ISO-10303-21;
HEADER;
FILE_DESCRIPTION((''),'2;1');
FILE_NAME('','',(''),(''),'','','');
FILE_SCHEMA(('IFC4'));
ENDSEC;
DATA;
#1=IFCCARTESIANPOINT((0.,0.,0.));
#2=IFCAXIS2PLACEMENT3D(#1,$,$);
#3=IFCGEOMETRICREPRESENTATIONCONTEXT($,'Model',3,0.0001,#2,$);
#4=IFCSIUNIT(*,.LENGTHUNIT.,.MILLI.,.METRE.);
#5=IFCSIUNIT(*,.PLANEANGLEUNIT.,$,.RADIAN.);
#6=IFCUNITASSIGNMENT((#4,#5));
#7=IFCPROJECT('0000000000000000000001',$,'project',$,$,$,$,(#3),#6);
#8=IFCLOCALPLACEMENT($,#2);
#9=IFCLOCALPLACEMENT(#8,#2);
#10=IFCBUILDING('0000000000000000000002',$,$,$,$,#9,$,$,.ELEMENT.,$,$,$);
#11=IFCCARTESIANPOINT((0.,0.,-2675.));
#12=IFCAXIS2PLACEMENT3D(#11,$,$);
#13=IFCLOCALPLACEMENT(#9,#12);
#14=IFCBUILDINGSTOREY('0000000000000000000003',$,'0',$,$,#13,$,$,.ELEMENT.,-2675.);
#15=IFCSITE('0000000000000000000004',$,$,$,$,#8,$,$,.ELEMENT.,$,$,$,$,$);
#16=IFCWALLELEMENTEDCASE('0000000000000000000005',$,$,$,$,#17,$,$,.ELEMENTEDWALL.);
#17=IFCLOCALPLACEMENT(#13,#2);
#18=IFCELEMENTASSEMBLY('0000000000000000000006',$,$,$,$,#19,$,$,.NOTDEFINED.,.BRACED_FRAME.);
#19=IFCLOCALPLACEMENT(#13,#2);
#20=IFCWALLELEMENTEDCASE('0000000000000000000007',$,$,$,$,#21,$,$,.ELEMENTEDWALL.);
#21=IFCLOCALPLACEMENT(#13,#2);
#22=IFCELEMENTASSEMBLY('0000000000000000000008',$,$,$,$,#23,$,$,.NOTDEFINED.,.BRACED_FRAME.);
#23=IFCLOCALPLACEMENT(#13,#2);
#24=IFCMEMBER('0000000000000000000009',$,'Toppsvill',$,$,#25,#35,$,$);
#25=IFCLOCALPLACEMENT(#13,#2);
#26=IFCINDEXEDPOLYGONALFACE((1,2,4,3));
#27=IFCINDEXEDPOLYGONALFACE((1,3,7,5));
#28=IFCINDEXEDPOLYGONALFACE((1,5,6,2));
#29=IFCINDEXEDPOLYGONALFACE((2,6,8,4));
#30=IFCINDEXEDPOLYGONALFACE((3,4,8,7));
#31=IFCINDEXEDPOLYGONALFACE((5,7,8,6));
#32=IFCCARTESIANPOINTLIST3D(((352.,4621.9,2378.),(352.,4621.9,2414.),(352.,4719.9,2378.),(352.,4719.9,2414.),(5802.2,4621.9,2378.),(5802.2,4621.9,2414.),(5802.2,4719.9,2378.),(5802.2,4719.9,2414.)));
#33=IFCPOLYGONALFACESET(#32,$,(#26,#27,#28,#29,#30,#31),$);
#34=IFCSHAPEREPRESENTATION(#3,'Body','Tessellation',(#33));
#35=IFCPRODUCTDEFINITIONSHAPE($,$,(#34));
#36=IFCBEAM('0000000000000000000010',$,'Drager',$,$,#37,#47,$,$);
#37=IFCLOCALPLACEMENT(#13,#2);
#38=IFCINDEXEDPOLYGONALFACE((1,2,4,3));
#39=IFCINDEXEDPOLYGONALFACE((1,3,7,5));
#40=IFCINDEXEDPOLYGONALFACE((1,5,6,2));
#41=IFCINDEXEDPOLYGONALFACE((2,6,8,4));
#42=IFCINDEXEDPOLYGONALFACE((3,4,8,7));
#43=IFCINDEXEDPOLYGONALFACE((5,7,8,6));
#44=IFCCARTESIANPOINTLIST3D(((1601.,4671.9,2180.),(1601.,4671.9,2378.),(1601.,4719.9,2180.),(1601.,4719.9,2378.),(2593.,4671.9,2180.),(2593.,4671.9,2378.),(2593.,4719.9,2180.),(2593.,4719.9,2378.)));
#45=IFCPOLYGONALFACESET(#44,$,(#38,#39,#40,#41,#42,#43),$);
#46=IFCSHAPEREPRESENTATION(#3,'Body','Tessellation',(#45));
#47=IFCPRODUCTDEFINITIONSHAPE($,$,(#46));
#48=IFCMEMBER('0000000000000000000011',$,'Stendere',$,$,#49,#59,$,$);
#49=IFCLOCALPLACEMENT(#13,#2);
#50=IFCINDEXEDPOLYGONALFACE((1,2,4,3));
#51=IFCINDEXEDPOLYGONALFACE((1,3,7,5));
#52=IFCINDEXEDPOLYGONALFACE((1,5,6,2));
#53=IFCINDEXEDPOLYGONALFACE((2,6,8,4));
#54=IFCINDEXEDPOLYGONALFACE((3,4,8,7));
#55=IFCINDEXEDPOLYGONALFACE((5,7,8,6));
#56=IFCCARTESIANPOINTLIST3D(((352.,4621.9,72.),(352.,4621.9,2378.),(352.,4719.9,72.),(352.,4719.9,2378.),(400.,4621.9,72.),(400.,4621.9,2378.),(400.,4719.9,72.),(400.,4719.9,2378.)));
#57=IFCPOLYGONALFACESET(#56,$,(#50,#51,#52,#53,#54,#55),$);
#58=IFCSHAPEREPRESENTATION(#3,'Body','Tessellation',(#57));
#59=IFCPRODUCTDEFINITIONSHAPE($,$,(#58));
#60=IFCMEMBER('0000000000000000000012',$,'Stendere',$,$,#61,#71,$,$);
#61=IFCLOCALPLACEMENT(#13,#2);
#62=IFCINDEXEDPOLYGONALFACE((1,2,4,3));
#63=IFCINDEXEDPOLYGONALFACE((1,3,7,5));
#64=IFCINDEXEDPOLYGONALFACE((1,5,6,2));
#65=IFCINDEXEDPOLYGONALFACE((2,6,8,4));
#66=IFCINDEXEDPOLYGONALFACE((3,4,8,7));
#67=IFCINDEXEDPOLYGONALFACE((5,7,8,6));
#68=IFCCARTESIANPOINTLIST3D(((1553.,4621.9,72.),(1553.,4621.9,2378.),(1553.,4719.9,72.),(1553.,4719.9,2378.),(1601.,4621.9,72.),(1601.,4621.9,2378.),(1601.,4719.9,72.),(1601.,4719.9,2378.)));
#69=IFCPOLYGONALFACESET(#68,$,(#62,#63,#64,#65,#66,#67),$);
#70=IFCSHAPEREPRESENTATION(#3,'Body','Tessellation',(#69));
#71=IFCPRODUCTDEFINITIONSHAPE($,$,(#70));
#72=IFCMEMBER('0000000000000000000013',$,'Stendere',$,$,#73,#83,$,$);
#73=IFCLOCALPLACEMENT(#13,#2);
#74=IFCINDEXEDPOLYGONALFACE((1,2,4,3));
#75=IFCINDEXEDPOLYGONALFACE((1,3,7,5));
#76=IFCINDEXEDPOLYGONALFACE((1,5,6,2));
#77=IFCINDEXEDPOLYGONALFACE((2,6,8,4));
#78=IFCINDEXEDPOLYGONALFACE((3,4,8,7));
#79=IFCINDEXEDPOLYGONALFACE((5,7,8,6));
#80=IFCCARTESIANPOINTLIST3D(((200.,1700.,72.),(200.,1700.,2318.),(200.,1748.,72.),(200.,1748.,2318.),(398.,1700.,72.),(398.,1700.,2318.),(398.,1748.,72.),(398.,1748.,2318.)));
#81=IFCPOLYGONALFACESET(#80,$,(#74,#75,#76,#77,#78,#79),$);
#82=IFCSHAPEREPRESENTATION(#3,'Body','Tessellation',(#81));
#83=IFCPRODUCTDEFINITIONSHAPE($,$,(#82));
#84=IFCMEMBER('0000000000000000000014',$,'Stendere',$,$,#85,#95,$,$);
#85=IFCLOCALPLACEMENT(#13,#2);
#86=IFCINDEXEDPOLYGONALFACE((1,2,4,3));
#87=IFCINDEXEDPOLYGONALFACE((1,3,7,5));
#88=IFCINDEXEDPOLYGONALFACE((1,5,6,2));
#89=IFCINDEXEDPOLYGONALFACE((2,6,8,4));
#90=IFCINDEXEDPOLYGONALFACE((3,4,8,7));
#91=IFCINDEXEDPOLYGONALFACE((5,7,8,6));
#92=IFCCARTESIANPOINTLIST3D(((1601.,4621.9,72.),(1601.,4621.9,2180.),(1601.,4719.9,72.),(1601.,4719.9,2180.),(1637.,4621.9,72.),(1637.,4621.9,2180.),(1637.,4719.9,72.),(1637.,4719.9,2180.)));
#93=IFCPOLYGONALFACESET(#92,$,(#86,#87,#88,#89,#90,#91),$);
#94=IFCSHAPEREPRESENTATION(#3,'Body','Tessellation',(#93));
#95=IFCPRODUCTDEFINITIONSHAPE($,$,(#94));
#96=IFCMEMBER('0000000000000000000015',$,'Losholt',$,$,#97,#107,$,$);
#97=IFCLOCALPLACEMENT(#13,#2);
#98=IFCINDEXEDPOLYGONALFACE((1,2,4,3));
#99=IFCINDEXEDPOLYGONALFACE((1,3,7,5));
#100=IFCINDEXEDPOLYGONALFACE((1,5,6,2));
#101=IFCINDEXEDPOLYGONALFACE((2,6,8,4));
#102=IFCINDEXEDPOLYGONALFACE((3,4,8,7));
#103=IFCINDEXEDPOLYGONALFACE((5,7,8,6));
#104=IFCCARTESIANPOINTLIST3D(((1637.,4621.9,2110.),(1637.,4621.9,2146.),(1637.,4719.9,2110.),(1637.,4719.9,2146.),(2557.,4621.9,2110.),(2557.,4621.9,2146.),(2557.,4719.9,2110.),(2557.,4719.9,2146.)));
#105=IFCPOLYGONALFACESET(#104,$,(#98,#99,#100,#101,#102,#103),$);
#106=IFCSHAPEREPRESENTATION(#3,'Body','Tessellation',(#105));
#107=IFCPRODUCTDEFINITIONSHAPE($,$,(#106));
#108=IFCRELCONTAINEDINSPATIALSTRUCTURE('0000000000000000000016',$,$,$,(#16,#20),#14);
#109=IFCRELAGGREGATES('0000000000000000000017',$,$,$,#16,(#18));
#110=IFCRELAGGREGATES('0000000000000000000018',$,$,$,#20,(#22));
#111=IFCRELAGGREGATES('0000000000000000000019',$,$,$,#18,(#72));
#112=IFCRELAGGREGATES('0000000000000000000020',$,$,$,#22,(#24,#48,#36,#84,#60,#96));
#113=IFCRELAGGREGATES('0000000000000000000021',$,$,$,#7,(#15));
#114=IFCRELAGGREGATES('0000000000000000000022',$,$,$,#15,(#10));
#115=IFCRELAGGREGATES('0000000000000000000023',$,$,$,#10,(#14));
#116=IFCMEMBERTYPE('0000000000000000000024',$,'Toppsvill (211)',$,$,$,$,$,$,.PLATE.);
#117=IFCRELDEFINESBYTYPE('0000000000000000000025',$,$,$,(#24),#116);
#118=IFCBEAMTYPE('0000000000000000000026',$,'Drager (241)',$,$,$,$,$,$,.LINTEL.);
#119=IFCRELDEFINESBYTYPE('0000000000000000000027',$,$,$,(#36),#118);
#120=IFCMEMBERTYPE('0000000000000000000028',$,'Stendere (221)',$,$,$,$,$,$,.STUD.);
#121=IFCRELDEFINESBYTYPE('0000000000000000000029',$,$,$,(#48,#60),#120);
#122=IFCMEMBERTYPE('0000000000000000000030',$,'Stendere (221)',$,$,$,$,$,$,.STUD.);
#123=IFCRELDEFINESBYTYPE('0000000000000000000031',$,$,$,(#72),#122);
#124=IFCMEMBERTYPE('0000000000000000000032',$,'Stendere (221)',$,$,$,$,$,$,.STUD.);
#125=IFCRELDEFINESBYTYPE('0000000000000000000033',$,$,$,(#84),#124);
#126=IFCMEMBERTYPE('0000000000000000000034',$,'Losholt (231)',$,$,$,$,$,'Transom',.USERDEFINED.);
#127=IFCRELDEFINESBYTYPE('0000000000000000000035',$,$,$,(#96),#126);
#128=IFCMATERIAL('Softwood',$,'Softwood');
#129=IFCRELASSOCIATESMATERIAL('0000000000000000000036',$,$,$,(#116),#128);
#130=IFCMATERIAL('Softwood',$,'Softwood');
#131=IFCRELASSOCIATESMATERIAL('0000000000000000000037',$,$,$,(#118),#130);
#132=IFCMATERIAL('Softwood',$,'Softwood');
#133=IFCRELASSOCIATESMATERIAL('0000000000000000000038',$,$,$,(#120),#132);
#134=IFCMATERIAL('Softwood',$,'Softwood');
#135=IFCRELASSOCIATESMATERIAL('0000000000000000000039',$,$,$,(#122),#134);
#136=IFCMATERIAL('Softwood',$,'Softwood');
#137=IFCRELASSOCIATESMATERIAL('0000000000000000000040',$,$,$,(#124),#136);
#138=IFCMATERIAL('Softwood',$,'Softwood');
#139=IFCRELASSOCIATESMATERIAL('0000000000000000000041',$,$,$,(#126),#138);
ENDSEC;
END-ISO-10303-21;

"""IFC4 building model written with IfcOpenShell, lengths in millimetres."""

from ifc_helpers import new_model, si_unit, frame, origin, place, context, project, spatial, rectangle, extrude, material, material_profile, profile_set, type_object, element, aggregate, save


model = new_model("IFC4")

# Units and contexts
model_context = context("Model", 3, precision=0.0001, world=origin())
ifc_project = project(units=[si_unit("LENGTHUNIT", "METRE", prefix="MILLI"), si_unit("PLANEANGLEUNIT", "RADIAN")], contexts=[model_context])

# Site, building, storey
site_placement = place(None, origin())
site = spatial("IfcSite", under=ifc_project, at=site_placement, CompositionType="ELEMENT")
building_placement = place(site_placement, origin())
building = spatial("IfcBuilding", under=site, at=building_placement, CompositionType="ELEMENT")
storey_placement = place(building_placement, frame((0.0, 0.0, -2675.0)))
storey = spatial("IfcBuildingStorey", under=building, at=storey_placement, Name="0", CompositionType="ELEMENT", Elevation=-2675.0)

# Wall, element assembly
wall_1_placement = place(storey_placement, frame((350.0, 1748.0, 0.0), z_axis=(0.0, -1.0, 0.0)))
wall_1 = element("IfcWallElementedCase", 1, at=wall_1_placement, inside=storey, PredefinedType="ELEMENTEDWALL")
assembly_1_placement = place(wall_1_placement, origin())
assembly_1 = element("IfcElementAssembly", 2, at=assembly_1_placement, AssemblyPlace="NOTDEFINED", PredefinedType="BRACED_FRAME")
aggregate(wall_1, [assembly_1])

# Wall, element assembly
wall_2_placement = place(storey_placement, frame((352.0, 4719.9, 0.0), z_axis=(0.0, -1.0, 0.0)))
wall_2 = element("IfcWallElementedCase", 3, at=wall_2_placement, inside=storey, PredefinedType="ELEMENTEDWALL")
assembly_2_placement = place(wall_2_placement, origin())
assembly_2 = element("IfcElementAssembly", 4, at=assembly_2_placement, AssemblyPlace="NOTDEFINED", PredefinedType="BRACED_FRAME")
aggregate(wall_2, [assembly_2])

# Member
ifc_material_1 = material(Name="Softwood", Category="Softwood")
ifc_material_profile_1 = material_profile(ifc_material_1, rectangle(XDim=36.0, YDim=98.0), Name="Toppsvill (211)")
ifc_profile_set_1 = profile_set([ifc_material_profile_1])
member_type_1 = type_object("IfcMemberType", Name="Toppsvill (211)", PredefinedType="PLATE", material=ifc_profile_set_1)
member_1_placement = place(assembly_2_placement, frame((0.0, 2396.0, 0.0), z_axis=(1.0, 0.0, 0.0), x_axis=(0.0, 1.0, 0.0)))
member_1 = element("IfcMember", 5, at=member_1_placement, type_object=member_type_1, Name="Toppsvill", context=model_context, shape_type="SweptSolid", body=[
    extrude(rectangle(XDim=36.0, YDim=98.0), frame((0.0, 49.0, 0.0)), (0.0, 0.0, 1.0), 5450.2),
])

# Beam
ifc_material_2 = material(Name="Softwood", Category="Softwood")
ifc_material_profile_2 = material_profile(ifc_material_2, rectangle(XDim=198.0, YDim=48.0), Name="Drager (241)")
ifc_profile_set_2 = profile_set([ifc_material_profile_2])
beam_type_1 = type_object("IfcBeamType", Name="Drager (241)", PredefinedType="LINTEL", material=ifc_profile_set_2)
beam_1_placement = place(assembly_2_placement, frame((1249.0, 2279.0, 0.0), z_axis=(1.0, 0.0, 0.0), x_axis=(0.0, 1.0, 0.0)))
beam_1 = element("IfcBeam", 6, at=beam_1_placement, type_object=beam_type_1, Name="Drager", context=model_context, shape_type="SweptSolid", body=[
    extrude(rectangle(XDim=198.0, YDim=48.0), frame((0.0, 24.0, 0.0)), (0.0, 0.0, 1.0), 992.0),
])

# Members
ifc_material_3 = material(Name="Softwood", Category="Softwood")
ifc_material_profile_3 = material_profile(ifc_material_3, rectangle(XDim=48.0, YDim=98.0), Name="Stendere (221)")
ifc_profile_set_3 = profile_set([ifc_material_profile_3])
member_type_2 = type_object("IfcMemberType", Name="Stendere (221)", PredefinedType="STUD", material=ifc_profile_set_3)
member_2_placement = place(assembly_2_placement, frame((24.0, 72.0, 0.0), z_axis=(0.0, 1.0, 0.0), x_axis=(-1.0, 0.0, 0.0)))
member_2 = element("IfcMember", 7, at=member_2_placement, type_object=member_type_2, Name="Stendere", context=model_context, shape_type="SweptSolid", body=[
    extrude(rectangle(XDim=48.0, YDim=98.0), frame((0.0, 49.0, 0.0)), (0.0, 0.0, 1.0), 2306.0),
])
member_3_placement = place(assembly_2_placement, frame((1225.0, 72.0, 0.0), z_axis=(0.0, 1.0, 0.0), x_axis=(-1.0, 0.0, 0.0)))
member_3 = element("IfcMember", 8, at=member_3_placement, type_object=member_type_2, Name="Stendere", context=model_context, shape_type="SweptSolid", body=[
    extrude(rectangle(XDim=48.0, YDim=98.0), frame((0.0, 49.0, 0.0)), (0.0, 0.0, 1.0), 2306.0),
])

# Members
ifc_material_4 = material(Name="Softwood", Category="Softwood")
ifc_material_profile_4 = material_profile(ifc_material_4, rectangle(XDim=198.0, YDim=48.0), Name="Stendere (221)")
ifc_profile_set_4 = profile_set([ifc_material_profile_4])
member_type_3 = type_object("IfcMemberType", Name="Stendere (221)", PredefinedType="STUD", material=ifc_profile_set_4)
member_4_placement = place(assembly_1_placement, frame((-51.0, 72.0, 0.0), z_axis=(0.0, 1.0, 0.0), x_axis=(-1.0, 0.0, 0.0)))
member_4 = element("IfcMember", 9, at=member_4_placement, type_object=member_type_3, Name="Stendere", context=model_context, shape_type="SweptSolid", body=[
    extrude(rectangle(XDim=198.0, YDim=48.0), frame((0.0, 24.0, 0.0)), (0.0, 0.0, 1.0), 2246.0),
])
aggregate(assembly_1, [member_4])
ifc_material_5 = material(Name="Softwood", Category="Softwood")
ifc_material_profile_5 = material_profile(ifc_material_5, rectangle(XDim=36.0, YDim=98.0), Name="Stendere (221)")
ifc_profile_set_5 = profile_set([ifc_material_profile_5])
member_type_4 = type_object("IfcMemberType", Name="Stendere (221)", PredefinedType="STUD", material=ifc_profile_set_5)
member_5_placement = place(assembly_2_placement, frame((1267.0, 72.0, 0.0), z_axis=(0.0, 1.0, 0.0), x_axis=(-1.0, 0.0, 0.0)))
member_5 = element("IfcMember", 10, at=member_5_placement, type_object=member_type_4, Name="Stendere", context=model_context, shape_type="SweptSolid", body=[
    extrude(rectangle(XDim=36.0, YDim=98.0), frame((0.0, 49.0, 0.0)), (0.0, 0.0, 1.0), 2108.0),
])
ifc_material_6 = material(Name="Softwood", Category="Softwood")
ifc_material_profile_6 = material_profile(ifc_material_6, rectangle(XDim=36.0, YDim=98.0), Name="Losholt (231)")
ifc_profile_set_6 = profile_set([ifc_material_profile_6])
member_type_5 = type_object("IfcMemberType", Name="Losholt (231)", ElementType="Transom", PredefinedType="USERDEFINED", material=ifc_profile_set_6)
member_6_placement = place(assembly_2_placement, frame((1285.0, 2128.0, 0.0), z_axis=(1.0, 0.0, 0.0), x_axis=(0.0, 1.0, 0.0)))
member_6 = element("IfcMember", 11, at=member_6_placement, type_object=member_type_5, Name="Losholt", context=model_context, shape_type="SweptSolid", body=[
    extrude(rectangle(XDim=36.0, YDim=98.0), frame((0.0, 49.0, 0.0)), (0.0, 0.0, 1.0), 920.0),
])
aggregate(assembly_2, [member_1, member_2, beam_1, member_5, member_3, member_6])

save(model, "model.ifc")
